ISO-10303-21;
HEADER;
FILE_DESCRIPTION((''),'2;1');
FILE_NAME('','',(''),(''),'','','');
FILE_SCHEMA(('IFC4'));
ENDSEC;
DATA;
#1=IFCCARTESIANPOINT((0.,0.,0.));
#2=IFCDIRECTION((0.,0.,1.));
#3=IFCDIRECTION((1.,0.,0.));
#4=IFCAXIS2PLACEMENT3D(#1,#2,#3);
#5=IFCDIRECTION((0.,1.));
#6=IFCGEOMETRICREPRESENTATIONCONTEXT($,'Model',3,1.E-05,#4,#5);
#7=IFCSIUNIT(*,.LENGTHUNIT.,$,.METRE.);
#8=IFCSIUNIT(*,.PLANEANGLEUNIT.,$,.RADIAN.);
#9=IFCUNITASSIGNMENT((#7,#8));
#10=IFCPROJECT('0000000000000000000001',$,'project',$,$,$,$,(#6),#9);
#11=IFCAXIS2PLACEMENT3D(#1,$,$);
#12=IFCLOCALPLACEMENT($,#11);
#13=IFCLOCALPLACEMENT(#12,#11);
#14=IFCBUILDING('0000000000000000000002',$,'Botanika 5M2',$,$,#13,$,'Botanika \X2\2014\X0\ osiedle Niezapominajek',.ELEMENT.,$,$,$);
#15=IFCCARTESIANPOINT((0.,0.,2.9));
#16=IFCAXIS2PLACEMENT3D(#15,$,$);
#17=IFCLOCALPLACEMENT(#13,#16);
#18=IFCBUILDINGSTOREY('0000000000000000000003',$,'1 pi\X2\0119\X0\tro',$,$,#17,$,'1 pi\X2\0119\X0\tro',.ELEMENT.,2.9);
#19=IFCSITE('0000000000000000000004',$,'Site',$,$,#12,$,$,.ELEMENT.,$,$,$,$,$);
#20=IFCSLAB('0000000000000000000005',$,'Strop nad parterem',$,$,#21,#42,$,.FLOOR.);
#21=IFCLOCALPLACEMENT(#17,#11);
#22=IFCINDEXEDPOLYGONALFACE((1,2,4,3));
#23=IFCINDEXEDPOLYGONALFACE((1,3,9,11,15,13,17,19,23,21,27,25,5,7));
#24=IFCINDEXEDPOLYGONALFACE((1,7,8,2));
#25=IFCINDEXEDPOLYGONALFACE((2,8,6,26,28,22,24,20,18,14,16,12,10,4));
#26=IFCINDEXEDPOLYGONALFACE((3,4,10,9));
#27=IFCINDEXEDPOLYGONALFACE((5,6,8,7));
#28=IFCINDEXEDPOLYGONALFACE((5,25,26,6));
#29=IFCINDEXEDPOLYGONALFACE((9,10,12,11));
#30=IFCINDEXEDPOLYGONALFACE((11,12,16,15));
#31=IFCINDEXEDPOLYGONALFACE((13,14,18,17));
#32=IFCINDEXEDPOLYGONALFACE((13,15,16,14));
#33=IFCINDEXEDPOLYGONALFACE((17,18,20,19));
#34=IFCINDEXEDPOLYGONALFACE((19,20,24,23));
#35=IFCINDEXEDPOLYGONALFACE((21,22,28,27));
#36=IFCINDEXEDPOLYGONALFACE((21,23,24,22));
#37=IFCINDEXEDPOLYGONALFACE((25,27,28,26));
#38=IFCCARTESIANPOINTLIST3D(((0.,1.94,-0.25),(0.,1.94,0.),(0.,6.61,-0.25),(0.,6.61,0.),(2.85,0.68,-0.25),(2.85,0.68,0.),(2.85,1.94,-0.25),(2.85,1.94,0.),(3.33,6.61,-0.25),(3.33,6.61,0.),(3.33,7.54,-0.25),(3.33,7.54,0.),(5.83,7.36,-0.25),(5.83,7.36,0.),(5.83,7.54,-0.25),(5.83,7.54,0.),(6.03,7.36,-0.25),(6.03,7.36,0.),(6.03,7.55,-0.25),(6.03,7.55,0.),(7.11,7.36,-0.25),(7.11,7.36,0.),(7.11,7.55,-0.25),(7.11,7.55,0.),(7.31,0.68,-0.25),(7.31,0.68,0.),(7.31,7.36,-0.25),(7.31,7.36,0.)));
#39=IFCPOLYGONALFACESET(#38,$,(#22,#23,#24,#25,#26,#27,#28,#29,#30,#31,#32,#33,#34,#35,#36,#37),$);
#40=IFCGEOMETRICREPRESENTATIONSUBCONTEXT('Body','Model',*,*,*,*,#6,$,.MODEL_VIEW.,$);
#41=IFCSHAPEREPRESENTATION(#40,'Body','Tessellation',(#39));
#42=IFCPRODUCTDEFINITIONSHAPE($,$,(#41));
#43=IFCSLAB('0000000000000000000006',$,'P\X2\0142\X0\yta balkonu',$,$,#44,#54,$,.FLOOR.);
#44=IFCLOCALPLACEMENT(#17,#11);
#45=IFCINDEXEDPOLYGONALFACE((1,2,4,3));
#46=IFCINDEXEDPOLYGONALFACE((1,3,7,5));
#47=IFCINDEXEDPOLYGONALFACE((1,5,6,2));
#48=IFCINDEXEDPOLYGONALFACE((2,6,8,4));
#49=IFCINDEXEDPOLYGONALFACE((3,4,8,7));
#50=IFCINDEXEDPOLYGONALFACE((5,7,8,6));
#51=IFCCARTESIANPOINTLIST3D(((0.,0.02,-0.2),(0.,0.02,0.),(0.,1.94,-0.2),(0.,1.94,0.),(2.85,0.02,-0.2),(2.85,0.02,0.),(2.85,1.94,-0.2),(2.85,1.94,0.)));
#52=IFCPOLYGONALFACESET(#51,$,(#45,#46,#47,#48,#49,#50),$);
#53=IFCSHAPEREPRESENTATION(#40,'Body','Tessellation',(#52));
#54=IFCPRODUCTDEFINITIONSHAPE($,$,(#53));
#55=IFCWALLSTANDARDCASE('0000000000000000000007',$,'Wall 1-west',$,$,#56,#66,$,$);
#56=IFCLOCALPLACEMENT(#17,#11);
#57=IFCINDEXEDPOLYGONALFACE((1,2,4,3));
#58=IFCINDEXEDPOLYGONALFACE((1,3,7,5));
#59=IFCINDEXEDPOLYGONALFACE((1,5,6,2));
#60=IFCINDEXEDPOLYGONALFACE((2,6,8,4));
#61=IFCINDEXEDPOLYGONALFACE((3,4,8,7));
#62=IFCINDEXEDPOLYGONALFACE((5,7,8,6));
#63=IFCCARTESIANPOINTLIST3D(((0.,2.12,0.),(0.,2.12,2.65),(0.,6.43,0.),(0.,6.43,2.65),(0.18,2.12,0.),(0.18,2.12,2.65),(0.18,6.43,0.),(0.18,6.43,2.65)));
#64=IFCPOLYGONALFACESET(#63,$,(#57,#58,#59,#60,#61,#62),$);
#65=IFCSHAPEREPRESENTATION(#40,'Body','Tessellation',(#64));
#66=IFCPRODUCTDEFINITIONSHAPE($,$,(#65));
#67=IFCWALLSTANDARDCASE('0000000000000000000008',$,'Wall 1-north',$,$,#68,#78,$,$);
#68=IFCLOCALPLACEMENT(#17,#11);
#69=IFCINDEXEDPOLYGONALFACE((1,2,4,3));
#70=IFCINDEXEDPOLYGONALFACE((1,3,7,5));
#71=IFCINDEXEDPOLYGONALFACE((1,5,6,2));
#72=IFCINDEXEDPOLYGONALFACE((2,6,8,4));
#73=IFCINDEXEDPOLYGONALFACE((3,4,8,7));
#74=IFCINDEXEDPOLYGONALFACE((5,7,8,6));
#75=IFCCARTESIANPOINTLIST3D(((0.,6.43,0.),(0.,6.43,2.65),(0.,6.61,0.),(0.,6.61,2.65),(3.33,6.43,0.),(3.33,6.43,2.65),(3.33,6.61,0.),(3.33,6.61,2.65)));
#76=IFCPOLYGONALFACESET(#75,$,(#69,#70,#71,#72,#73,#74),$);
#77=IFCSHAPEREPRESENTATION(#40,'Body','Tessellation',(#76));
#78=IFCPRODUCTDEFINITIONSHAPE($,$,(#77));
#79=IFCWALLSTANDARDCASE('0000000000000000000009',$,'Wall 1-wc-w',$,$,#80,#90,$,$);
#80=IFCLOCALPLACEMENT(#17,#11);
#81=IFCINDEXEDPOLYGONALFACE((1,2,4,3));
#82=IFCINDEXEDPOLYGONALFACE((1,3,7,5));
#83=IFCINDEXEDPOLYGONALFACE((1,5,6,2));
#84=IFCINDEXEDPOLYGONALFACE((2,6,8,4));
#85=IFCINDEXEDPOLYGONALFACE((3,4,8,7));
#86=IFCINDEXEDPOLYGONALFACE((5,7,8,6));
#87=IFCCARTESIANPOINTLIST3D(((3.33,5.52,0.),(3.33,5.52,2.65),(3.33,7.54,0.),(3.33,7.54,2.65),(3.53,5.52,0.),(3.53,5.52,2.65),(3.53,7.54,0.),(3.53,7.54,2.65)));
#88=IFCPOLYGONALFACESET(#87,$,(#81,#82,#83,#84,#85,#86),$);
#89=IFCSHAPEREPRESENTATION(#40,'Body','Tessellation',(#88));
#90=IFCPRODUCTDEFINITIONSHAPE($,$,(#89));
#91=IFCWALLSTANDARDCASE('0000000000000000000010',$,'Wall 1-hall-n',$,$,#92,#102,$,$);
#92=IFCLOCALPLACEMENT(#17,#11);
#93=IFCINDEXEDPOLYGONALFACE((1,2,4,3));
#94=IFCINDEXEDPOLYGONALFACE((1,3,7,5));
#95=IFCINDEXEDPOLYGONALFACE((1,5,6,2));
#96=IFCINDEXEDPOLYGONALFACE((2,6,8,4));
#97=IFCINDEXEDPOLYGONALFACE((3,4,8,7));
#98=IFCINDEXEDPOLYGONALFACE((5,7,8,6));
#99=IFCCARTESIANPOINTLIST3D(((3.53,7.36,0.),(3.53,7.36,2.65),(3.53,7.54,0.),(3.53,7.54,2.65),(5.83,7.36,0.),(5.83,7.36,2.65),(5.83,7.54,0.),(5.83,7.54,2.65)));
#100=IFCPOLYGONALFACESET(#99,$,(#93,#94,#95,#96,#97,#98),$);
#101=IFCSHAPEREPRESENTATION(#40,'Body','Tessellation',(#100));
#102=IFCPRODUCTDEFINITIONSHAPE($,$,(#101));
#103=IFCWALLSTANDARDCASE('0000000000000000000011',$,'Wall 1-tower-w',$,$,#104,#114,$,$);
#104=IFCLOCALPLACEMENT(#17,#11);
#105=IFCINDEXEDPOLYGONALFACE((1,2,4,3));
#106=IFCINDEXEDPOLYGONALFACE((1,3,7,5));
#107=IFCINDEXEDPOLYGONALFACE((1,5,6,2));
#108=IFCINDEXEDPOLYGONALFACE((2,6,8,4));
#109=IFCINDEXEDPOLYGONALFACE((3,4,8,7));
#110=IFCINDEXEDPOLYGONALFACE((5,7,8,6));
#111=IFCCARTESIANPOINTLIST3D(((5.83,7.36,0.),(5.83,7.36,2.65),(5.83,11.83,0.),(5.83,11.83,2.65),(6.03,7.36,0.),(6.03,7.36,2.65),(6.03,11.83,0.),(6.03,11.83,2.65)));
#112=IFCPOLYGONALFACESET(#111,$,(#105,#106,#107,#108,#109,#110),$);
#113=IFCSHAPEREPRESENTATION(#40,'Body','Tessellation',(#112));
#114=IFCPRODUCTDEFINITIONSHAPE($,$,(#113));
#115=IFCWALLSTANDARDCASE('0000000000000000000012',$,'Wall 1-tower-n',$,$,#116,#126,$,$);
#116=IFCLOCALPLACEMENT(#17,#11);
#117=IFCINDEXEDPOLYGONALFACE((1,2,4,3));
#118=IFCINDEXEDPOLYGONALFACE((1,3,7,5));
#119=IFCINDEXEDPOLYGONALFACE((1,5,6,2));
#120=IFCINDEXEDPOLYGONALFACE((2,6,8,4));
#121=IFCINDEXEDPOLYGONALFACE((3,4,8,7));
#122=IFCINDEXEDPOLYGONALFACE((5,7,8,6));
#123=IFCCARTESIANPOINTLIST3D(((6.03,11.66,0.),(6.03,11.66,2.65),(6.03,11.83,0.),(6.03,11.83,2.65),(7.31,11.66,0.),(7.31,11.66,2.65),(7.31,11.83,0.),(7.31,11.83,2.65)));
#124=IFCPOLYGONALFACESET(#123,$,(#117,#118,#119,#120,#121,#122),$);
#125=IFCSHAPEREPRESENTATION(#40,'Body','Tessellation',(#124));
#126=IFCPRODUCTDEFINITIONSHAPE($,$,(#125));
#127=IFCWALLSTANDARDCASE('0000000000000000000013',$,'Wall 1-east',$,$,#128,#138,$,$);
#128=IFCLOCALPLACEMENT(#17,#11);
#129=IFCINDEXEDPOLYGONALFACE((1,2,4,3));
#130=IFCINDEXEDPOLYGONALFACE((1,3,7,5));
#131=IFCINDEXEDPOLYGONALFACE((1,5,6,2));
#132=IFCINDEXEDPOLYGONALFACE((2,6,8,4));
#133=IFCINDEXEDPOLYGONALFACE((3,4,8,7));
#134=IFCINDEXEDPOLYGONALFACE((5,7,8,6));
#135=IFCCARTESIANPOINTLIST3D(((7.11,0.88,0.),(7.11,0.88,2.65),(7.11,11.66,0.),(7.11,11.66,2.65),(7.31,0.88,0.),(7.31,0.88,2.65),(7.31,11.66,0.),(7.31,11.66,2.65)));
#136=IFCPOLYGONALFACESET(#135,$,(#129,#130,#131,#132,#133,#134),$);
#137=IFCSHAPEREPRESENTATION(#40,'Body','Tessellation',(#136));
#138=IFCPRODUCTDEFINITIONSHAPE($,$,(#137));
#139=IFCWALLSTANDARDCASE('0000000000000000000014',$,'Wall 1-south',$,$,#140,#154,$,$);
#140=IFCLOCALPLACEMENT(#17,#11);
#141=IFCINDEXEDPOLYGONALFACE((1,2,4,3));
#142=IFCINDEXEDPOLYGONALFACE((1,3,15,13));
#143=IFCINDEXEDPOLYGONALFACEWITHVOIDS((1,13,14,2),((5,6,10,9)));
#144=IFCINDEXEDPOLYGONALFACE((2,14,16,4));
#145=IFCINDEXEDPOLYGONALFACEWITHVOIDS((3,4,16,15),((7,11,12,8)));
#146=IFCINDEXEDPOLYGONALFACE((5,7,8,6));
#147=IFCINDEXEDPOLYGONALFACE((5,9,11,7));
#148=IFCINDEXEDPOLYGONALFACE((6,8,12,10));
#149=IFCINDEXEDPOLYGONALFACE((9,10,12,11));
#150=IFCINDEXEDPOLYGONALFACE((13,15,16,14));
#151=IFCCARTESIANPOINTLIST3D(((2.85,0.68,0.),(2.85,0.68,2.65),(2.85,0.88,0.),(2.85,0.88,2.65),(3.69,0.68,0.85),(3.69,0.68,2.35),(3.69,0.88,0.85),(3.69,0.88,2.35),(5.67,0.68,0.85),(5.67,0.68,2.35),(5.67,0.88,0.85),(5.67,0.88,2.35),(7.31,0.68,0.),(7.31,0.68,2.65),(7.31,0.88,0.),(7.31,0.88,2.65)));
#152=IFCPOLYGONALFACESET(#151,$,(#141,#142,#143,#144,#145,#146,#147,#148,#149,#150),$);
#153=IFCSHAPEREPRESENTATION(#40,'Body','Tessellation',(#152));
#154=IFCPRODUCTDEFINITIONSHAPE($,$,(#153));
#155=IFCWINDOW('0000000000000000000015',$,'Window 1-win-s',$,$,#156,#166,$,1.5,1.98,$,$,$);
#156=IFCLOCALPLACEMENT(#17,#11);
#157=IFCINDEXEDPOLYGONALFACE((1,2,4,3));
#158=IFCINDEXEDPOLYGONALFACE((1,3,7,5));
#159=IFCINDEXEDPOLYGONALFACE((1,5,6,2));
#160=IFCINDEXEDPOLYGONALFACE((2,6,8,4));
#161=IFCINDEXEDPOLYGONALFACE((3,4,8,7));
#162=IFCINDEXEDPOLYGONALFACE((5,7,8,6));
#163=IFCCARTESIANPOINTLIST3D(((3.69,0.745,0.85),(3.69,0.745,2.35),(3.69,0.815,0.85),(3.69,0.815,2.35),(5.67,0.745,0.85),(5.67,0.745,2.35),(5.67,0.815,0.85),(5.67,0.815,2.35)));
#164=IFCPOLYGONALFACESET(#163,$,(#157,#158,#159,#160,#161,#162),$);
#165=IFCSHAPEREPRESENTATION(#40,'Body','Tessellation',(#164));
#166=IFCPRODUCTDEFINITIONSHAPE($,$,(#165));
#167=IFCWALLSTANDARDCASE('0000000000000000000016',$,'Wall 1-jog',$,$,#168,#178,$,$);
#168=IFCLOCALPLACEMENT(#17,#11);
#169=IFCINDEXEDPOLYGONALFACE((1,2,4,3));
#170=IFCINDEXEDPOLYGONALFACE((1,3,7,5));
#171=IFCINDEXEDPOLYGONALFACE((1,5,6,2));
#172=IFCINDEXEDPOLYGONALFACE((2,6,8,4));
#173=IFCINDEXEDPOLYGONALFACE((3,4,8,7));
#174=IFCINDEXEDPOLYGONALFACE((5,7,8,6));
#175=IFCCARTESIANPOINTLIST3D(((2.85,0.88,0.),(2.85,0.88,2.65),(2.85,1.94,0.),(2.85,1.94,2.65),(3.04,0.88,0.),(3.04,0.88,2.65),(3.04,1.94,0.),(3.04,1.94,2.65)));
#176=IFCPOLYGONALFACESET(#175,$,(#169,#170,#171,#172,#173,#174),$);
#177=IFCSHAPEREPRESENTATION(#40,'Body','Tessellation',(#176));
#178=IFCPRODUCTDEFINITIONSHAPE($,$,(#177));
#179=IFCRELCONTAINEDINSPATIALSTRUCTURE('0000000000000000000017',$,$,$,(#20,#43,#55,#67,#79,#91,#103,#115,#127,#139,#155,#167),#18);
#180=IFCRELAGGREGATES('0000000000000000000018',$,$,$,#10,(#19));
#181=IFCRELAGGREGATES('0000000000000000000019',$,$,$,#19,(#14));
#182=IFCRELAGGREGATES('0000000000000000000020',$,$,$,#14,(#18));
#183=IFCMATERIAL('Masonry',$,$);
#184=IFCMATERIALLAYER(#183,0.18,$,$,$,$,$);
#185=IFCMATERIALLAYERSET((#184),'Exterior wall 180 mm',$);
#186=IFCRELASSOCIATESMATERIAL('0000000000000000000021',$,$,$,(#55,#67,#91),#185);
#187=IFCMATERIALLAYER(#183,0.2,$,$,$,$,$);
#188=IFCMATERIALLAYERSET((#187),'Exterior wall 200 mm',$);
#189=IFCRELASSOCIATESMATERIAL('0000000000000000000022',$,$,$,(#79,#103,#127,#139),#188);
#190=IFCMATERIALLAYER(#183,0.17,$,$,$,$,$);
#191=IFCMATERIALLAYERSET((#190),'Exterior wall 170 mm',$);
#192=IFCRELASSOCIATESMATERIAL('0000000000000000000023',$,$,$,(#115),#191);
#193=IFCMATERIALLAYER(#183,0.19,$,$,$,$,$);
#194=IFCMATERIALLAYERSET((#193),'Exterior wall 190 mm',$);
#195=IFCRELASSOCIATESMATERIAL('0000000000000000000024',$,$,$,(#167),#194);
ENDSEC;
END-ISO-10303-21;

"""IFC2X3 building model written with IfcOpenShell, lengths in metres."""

from ifc_helpers import new_model, si_unit, direction, frame, frame_2d, origin, origin_with_axes, place, context, subcontext, project, spatial, polyline, rectangle, outline, extrude, material, layer, layer_set, layer_usage, element, fill, save


model = new_model("IFC2X3")

# Units and contexts
model_context = context("Model", 3, precision=1e-05, world=origin_with_axes(), true_north=direction((0.0, 1.0)))
body_context = subcontext(model_context, "Body", "Model", "MODEL_VIEW")
ifc_project = project(units=[si_unit("LENGTHUNIT", "METRE"), si_unit("PLANEANGLEUNIT", "RADIAN")], contexts=[model_context])

# Site, building, storey
site_placement = place(None, origin())
site = spatial("IfcSite", under=ifc_project, at=site_placement, Name="Site", CompositionType="ELEMENT")
building_placement = place(site_placement, origin())
building = spatial("IfcBuilding", under=site, at=building_placement, Name="Botanika 5M2", LongName="Botanika — osiedle Niezapominajek", CompositionType="ELEMENT")
storey_placement = place(building_placement, frame((0.0, 0.0, 2.9)))
storey = spatial("IfcBuildingStorey", under=building, at=storey_placement, Name="1 piętro", LongName="1 piętro", CompositionType="ELEMENT", Elevation=2.9)

# Slabs
slab_1_placement = place(storey_placement, frame((0.0, 0.0, -0.25)))
element("IfcSlab", 1, at=slab_1_placement, inside=storey, Name="Strop nad parterem", PredefinedType="FLOOR", context=body_context, shape_type="SweptSolid", body=[
    extrude(outline(polyline([(0.0, 6.61), (3.33, 6.61), (3.33, 7.54), (5.83, 7.54), (5.83, 7.36), (6.03, 7.36), (6.03, 7.55), (7.11, 7.55), (7.11, 7.36), (7.31, 7.36), (7.31, 0.68), (2.85, 0.68), (2.85, 1.94), (0.0, 1.94), (0.0, 6.61)])), origin_with_axes(), (0.0, 0.0, 1.0), 0.25),
])
slab_2_placement = place(storey_placement, frame((0.0, 0.0, -0.2)))
element("IfcSlab", 2, at=slab_2_placement, inside=storey, Name="Płyta balkonu", PredefinedType="FLOOR", context=body_context, shape_type="SweptSolid", body=[
    extrude(outline(polyline([(0.0, 1.94), (2.85, 1.94), (2.85, 0.02), (0.0, 0.02), (0.0, 1.94)])), origin_with_axes(), (0.0, 0.0, 1.0), 0.2),
])

# Walls
ifc_material_1 = material(Name="Masonry")
ifc_layer_1 = layer(ifc_material_1, 0.18)
ifc_layer_set_1 = layer_set([ifc_layer_1], Name="Exterior wall 180 mm")
ifc_layer_usage_1 = layer_usage(ifc_layer_set_1, "AXIS2", "POSITIVE", -0.09)
wall_1_placement = place(storey_placement, frame((0.09, 6.43, 0.0), z_axis=(0.0, 0.0, 1.0), x_axis=(0.0, -1.0, 0.0)))
element("IfcWallStandardCase", 3, at=wall_1_placement, inside=storey, material=ifc_layer_usage_1, Name="Wall 1-west", context=body_context, shape_type="SweptSolid", body=[
    extrude(rectangle(XDim=4.31, YDim=0.18, at=frame_2d((2.155, 0.0))), origin_with_axes(), (0.0, 0.0, 1.0), 2.65),
])
wall_2_placement = place(storey_placement, frame((0.0, 6.52, 0.0)))
element("IfcWallStandardCase", 4, at=wall_2_placement, inside=storey, material=ifc_layer_usage_1, Name="Wall 1-north", context=body_context, shape_type="SweptSolid", body=[
    extrude(rectangle(XDim=3.33, YDim=0.18, at=frame_2d((1.665, 0.0))), origin_with_axes(), (0.0, 0.0, 1.0), 2.65),
])
ifc_layer_2 = layer(ifc_material_1, 0.2)
ifc_layer_set_2 = layer_set([ifc_layer_2], Name="Exterior wall 200 mm")
ifc_layer_usage_2 = layer_usage(ifc_layer_set_2, "AXIS2", "POSITIVE", -0.1)
wall_3_placement = place(storey_placement, frame((3.43, 7.54, 0.0), z_axis=(0.0, 0.0, 1.0), x_axis=(0.0, -1.0, 0.0)))
element("IfcWallStandardCase", 5, at=wall_3_placement, inside=storey, material=ifc_layer_usage_2, Name="Wall 1-wc-w", context=body_context, shape_type="SweptSolid", body=[
    extrude(rectangle(XDim=2.02, YDim=0.2, at=frame_2d((1.01, 0.0))), origin_with_axes(), (0.0, 0.0, 1.0), 2.65),
])
wall_4_placement = place(storey_placement, frame((3.53, 7.45, 0.0)))
element("IfcWallStandardCase", 6, at=wall_4_placement, inside=storey, material=ifc_layer_usage_1, Name="Wall 1-hall-n", context=body_context, shape_type="SweptSolid", body=[
    extrude(rectangle(XDim=2.3, YDim=0.18, at=frame_2d((1.15, 0.0))), origin_with_axes(), (0.0, 0.0, 1.0), 2.65),
])
wall_5_placement = place(storey_placement, frame((5.93, 11.83, 0.0), z_axis=(0.0, 0.0, 1.0), x_axis=(0.0, -1.0, 0.0)))
element("IfcWallStandardCase", 7, at=wall_5_placement, inside=storey, material=ifc_layer_usage_2, Name="Wall 1-tower-w", context=body_context, shape_type="SweptSolid", body=[
    extrude(rectangle(XDim=4.47, YDim=0.2, at=frame_2d((2.235, 0.0))), origin_with_axes(), (0.0, 0.0, 1.0), 2.65),
])
ifc_layer_3 = layer(ifc_material_1, 0.17)
ifc_layer_set_3 = layer_set([ifc_layer_3], Name="Exterior wall 170 mm")
ifc_layer_usage_3 = layer_usage(ifc_layer_set_3, "AXIS2", "POSITIVE", -0.085)
wall_6_placement = place(storey_placement, frame((6.03, 11.745, 0.0)))
element("IfcWallStandardCase", 8, at=wall_6_placement, inside=storey, material=ifc_layer_usage_3, Name="Wall 1-tower-n", context=body_context, shape_type="SweptSolid", body=[
    extrude(rectangle(XDim=1.28, YDim=0.17, at=frame_2d((0.64, 0.0))), origin_with_axes(), (0.0, 0.0, 1.0), 2.65),
])
wall_7_placement = place(storey_placement, frame((7.21, 11.66, 0.0), z_axis=(0.0, 0.0, 1.0), x_axis=(0.0, -1.0, 0.0)))
element("IfcWallStandardCase", 9, at=wall_7_placement, inside=storey, material=ifc_layer_usage_2, Name="Wall 1-east", context=body_context, shape_type="SweptSolid", body=[
    extrude(rectangle(XDim=10.78, YDim=0.2, at=frame_2d((5.39, 0.0))), origin_with_axes(), (0.0, 0.0, 1.0), 2.65),
])

# Wall, opening, window
wall_8_placement = place(storey_placement, frame((2.85, 0.78, 0.0)))
wall_8 = element("IfcWallStandardCase", 10, at=wall_8_placement, inside=storey, material=ifc_layer_usage_2, Name="Wall 1-south", context=body_context, shape_type="SweptSolid", body=[
    extrude(rectangle(XDim=4.46, YDim=0.2, at=frame_2d((2.23, 0.0))), origin_with_axes(), (0.0, 0.0, 1.0), 2.65),
])
opening_1_placement = place(wall_8_placement, frame((0.84, 0.15, 0.85), z_axis=(0.0, -1.0, 0.0), x_axis=(1.0, 0.0, 0.0)))
opening_1 = element("IfcOpeningElement", 11, at=opening_1_placement, cuts=wall_8, context=body_context, shape_type="SweptSolid", body=[
    extrude(rectangle(XDim=1.98, YDim=1.5, at=frame_2d((0.99, 0.75))), origin_with_axes(), (0.0, 0.0, 1.0), 0.3),
])
window_placement = place(wall_8_placement, frame((0.84, 0.0, 0.85)))
window = element("IfcWindow", 12, at=window_placement, inside=storey, Name="Window 1-win-s", OverallHeight=1.5, OverallWidth=1.98, context=body_context, shape_type="SweptSolid", body=[
    extrude(rectangle(XDim=1.98, YDim=0.07, at=frame_2d((0.99, 0.0))), origin_with_axes(), (0.0, 0.0, 1.0), 1.5),
])
fill(opening_1, window)

# Wall
ifc_layer_4 = layer(ifc_material_1, 0.19)
ifc_layer_set_4 = layer_set([ifc_layer_4], Name="Exterior wall 190 mm")
ifc_layer_usage_4 = layer_usage(ifc_layer_set_4, "AXIS2", "POSITIVE", -0.095)
wall_9_placement = place(storey_placement, frame((2.945, 1.94, 0.0), z_axis=(0.0, 0.0, 1.0), x_axis=(0.0, -1.0, 0.0)))
element("IfcWallStandardCase", 13, at=wall_9_placement, inside=storey, material=ifc_layer_usage_4, Name="Wall 1-jog", context=body_context, shape_type="SweptSolid", body=[
    extrude(rectangle(XDim=1.06, YDim=0.19, at=frame_2d((0.53, 0.0))), origin_with_axes(), (0.0, 0.0, 1.0), 2.65),
])

save(model, "model.ifc")
